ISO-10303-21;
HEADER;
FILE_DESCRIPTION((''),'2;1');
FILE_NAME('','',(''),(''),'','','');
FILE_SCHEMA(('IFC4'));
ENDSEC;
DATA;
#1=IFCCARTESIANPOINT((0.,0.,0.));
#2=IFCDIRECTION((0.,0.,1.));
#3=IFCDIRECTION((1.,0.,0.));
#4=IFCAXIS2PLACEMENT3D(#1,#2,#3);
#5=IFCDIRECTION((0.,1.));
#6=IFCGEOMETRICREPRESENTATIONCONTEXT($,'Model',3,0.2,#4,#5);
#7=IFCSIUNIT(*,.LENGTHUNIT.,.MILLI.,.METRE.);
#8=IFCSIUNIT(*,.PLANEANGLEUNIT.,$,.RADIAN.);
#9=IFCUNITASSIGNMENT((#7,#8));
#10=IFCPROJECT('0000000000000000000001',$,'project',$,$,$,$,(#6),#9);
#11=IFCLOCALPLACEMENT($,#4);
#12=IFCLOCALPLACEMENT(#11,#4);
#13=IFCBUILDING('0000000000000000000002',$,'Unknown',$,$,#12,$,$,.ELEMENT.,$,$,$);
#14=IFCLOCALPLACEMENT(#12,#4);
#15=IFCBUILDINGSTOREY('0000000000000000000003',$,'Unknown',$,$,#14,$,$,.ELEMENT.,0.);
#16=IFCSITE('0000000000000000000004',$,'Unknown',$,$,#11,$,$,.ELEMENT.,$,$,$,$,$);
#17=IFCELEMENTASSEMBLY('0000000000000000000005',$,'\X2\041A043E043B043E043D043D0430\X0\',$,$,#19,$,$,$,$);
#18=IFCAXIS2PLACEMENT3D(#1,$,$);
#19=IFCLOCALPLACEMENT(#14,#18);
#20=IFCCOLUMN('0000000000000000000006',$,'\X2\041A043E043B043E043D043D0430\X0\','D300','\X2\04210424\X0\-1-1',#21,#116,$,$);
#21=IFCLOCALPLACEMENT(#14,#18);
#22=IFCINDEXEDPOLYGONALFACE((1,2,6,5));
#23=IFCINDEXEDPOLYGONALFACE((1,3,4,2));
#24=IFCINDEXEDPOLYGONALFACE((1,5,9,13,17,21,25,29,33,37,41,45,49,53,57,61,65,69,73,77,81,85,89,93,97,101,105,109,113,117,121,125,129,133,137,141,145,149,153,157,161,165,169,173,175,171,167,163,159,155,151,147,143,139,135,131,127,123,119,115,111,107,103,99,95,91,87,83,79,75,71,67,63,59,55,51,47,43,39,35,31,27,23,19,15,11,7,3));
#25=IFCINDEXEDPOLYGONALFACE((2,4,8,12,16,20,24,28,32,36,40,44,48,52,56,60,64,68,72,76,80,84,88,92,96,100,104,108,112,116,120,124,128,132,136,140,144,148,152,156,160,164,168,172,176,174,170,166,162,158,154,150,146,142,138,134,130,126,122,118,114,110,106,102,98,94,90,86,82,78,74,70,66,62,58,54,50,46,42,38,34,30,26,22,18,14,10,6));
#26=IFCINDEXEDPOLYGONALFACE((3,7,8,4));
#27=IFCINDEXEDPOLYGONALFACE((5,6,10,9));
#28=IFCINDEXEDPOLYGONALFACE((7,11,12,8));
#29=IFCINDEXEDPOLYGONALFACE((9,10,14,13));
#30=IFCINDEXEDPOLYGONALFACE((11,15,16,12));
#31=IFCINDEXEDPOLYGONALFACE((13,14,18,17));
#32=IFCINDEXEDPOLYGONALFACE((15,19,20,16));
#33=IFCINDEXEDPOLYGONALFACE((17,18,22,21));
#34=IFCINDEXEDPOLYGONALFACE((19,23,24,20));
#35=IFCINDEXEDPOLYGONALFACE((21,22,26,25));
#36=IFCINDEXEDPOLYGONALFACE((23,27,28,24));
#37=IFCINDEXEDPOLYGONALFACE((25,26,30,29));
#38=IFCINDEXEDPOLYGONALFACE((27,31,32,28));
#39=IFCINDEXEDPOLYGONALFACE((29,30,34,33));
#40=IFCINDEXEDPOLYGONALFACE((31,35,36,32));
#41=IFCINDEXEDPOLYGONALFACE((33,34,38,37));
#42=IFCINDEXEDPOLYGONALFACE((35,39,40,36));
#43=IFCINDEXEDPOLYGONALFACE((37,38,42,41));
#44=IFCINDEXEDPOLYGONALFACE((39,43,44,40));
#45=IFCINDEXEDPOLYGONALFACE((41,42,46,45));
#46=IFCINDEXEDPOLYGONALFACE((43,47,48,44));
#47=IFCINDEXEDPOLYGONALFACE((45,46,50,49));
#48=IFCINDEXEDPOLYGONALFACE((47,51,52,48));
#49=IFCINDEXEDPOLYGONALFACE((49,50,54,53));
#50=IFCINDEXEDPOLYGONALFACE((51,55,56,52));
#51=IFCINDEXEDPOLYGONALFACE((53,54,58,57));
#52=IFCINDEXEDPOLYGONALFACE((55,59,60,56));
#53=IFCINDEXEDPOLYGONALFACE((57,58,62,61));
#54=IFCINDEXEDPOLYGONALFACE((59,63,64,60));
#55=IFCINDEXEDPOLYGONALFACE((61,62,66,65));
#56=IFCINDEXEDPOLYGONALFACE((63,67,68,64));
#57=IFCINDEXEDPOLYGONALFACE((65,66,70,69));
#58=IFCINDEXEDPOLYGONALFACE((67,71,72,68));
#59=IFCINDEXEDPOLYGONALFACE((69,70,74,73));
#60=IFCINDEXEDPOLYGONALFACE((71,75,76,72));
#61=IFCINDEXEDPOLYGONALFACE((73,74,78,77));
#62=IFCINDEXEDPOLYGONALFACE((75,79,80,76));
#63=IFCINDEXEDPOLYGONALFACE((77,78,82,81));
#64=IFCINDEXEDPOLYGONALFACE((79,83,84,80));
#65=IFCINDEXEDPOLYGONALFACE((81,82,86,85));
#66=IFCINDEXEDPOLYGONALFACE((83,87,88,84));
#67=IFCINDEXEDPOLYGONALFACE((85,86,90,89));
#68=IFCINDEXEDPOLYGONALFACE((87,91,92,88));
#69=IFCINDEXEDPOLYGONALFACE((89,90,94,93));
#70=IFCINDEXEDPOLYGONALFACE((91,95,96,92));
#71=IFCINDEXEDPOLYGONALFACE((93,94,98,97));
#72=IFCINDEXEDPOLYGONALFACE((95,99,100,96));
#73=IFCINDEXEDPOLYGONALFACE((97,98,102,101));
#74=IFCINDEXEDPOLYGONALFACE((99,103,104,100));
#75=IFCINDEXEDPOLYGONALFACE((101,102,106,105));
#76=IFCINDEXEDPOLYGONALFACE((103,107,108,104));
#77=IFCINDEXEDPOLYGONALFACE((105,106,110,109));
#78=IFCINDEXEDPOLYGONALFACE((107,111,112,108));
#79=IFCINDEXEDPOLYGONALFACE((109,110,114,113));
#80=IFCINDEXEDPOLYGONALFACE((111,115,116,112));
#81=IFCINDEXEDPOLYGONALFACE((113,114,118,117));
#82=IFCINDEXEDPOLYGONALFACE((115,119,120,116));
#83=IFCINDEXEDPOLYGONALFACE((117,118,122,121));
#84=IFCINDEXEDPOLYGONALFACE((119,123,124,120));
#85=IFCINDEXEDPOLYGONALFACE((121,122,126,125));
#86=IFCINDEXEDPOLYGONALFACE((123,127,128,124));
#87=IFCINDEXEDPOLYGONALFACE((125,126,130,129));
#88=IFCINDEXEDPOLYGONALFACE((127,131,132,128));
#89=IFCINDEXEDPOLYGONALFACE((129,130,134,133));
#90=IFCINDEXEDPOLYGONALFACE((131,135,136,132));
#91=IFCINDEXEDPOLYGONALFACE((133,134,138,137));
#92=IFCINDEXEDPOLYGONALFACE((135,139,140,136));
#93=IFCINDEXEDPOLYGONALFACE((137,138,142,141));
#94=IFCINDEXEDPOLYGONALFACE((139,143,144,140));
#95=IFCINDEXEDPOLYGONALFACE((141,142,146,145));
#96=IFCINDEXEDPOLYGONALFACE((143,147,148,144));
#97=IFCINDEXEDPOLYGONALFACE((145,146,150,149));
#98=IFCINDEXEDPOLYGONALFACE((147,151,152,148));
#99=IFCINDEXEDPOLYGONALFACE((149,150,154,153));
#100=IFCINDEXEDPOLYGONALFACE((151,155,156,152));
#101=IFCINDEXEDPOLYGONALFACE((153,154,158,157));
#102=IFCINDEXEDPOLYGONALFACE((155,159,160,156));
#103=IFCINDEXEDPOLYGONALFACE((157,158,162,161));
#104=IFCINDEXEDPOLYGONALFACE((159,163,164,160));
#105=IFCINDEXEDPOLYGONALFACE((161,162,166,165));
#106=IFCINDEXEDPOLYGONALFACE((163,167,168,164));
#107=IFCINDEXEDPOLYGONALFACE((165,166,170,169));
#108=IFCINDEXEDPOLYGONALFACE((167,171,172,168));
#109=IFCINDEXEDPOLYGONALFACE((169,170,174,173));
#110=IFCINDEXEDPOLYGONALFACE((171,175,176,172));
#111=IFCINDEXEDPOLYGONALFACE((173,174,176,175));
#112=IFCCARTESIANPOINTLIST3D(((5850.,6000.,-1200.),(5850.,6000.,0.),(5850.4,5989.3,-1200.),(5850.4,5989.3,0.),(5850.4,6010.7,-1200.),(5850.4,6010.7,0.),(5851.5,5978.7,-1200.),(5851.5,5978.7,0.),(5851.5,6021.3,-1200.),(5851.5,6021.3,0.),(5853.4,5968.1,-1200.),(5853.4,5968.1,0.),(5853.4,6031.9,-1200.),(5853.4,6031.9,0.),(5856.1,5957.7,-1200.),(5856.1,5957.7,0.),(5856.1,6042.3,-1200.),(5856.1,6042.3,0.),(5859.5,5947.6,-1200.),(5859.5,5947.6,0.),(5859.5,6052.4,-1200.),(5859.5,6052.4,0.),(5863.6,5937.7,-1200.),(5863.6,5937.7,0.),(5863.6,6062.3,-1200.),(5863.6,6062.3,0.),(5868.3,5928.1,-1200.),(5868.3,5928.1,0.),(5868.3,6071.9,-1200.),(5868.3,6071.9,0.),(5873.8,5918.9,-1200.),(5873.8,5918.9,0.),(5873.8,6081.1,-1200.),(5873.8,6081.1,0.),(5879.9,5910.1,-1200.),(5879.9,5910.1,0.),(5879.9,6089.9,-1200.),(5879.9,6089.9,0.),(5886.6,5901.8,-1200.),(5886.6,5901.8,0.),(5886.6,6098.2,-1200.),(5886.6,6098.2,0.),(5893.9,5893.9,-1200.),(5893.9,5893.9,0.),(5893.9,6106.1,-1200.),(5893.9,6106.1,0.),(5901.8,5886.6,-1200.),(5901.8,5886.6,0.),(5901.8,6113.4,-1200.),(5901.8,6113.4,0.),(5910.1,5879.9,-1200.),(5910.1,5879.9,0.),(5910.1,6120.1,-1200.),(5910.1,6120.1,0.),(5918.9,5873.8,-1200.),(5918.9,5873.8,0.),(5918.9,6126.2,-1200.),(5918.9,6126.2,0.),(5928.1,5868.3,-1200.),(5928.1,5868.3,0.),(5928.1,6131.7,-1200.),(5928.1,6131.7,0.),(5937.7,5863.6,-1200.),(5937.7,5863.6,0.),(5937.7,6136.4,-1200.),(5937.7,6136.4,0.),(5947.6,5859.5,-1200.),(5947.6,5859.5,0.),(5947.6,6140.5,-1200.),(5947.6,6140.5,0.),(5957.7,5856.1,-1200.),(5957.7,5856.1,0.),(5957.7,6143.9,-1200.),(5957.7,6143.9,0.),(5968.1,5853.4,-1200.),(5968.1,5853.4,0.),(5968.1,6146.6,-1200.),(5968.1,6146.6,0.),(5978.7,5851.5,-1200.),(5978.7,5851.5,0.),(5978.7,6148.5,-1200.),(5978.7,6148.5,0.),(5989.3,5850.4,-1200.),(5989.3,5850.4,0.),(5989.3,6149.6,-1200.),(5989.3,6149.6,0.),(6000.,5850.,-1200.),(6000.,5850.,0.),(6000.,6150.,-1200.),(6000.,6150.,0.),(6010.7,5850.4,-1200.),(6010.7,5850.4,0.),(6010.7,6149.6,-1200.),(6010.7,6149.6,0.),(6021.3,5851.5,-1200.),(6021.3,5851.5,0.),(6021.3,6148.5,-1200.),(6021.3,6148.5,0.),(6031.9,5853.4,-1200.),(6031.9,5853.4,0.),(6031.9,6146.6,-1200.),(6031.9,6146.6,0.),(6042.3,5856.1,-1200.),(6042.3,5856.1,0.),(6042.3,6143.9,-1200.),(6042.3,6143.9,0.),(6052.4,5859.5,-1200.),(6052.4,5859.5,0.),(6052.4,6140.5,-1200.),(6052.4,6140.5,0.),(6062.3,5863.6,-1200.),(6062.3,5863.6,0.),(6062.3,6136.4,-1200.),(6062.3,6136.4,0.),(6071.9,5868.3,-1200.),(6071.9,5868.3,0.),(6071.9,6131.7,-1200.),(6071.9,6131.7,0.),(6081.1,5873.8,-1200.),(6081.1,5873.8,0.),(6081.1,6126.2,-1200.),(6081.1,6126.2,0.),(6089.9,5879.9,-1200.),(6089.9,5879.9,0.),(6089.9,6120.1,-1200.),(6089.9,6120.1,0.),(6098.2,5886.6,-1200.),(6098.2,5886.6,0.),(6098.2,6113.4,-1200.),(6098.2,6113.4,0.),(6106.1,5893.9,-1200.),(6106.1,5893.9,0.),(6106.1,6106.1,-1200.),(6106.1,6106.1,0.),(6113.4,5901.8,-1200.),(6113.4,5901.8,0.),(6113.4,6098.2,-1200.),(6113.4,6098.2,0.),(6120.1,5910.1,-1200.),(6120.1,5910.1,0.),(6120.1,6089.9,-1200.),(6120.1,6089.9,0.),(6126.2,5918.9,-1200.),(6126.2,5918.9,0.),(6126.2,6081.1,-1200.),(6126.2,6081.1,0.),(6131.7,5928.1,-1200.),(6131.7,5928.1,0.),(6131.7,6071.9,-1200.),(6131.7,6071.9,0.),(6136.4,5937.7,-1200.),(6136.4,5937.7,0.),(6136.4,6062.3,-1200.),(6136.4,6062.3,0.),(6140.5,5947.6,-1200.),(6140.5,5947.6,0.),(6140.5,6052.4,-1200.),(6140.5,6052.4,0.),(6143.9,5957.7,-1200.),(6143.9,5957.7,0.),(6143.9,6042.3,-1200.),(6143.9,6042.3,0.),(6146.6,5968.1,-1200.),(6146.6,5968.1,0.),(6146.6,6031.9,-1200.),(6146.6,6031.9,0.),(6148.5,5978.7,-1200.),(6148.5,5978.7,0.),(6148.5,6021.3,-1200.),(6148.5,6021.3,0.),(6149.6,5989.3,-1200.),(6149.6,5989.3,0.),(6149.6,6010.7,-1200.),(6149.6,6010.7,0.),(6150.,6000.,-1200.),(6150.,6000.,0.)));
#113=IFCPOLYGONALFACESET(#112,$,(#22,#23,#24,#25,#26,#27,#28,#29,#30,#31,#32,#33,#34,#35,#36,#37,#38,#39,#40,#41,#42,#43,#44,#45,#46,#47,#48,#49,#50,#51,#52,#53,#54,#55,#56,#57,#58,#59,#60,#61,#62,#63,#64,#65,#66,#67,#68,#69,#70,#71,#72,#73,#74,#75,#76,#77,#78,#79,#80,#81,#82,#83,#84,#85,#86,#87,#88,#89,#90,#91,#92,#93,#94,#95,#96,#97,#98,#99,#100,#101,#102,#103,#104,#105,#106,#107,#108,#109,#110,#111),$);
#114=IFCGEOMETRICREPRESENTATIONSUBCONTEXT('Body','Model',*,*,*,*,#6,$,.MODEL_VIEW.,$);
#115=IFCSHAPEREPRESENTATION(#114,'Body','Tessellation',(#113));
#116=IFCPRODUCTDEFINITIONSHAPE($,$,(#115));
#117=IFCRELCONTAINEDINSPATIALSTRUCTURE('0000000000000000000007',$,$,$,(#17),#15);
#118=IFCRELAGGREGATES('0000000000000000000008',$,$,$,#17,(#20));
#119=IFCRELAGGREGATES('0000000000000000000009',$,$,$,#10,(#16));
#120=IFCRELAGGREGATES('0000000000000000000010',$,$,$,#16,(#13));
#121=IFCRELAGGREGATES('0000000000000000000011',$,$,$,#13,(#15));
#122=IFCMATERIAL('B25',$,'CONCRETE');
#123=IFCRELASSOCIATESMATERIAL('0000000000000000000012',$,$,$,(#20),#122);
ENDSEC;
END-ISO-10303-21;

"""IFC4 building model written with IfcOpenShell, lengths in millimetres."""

from ifc_helpers import new_model, si_unit, direction, frame, origin_with_axes, place, context, subcontext, project, spatial, line, indexed_curve, outline, extrude, material, element, aggregate, save


model = new_model("IFC4")

# Units and contexts
model_context = context("Model", 3, precision=0.2, world=origin_with_axes(), true_north=direction((0.0, 1.0)))
body_context = subcontext(model_context, "Body", "Model", "MODEL_VIEW")
ifc_project = project(units=[si_unit("LENGTHUNIT", "METRE", prefix="MILLI"), si_unit("PLANEANGLEUNIT", "RADIAN")], contexts=[model_context])

# Site, building, storey
site_placement = place(None, origin_with_axes())
site = spatial("IfcSite", under=ifc_project, at=site_placement, Name="Unknown", CompositionType="ELEMENT")
building_placement = place(site_placement, origin_with_axes())
building = spatial("IfcBuilding", under=site, at=building_placement, Name="Unknown", CompositionType="ELEMENT")
storey_placement = place(building_placement, origin_with_axes())
storey = spatial("IfcBuildingStorey", under=building, at=storey_placement, Name="Unknown", CompositionType="ELEMENT", Elevation=0.0)

# Element assembly, column
assembly_1_placement = place(storey_placement, frame((6000.0, 6000.0, -1200.0), z_axis=(-1.0, 0.0, 0.0), x_axis=(0.0, 0.0, 1.0)))
assembly_1 = element("IfcElementAssembly", 1, at=assembly_1_placement, inside=storey, Name="Колонна")
ifc_material_1 = material(Name="B25", Category="CONCRETE")
column_1_placement = place(assembly_1_placement, origin_with_axes())
column_1 = element("IfcColumn", 2, at=column_1_placement, material=ifc_material_1, Name="Колонна", Description="D300", ObjectType="СФ-1-1", context=body_context, shape_type="SolidModel", body=[
    extrude(outline(indexed_curve([(150.0, 0.0), (149.6, 10.7), (148.5, 21.3), (146.6, 31.9), (143.9, 42.3), (140.5, 52.4), (136.4, 62.3), (131.7, 71.9), (126.2, 81.1), (120.1, 89.9), (113.4, 98.2), (106.1, 106.1), (98.2, 113.4), (89.9, 120.1), (81.1, 126.2), (71.9, 131.7), (62.3, 136.4), (52.4, 140.5), (42.3, 143.9), (31.9, 146.6), (21.3, 148.5), (10.7, 149.6), (0.0, 150.0), (-10.7, 149.6), (-21.3, 148.5), (-31.9, 146.6), (-42.3, 143.9), (-52.4, 140.5), (-62.3, 136.4), (-71.9, 131.7), (-81.1, 126.2), (-89.9, 120.1), (-98.2, 113.4), (-106.1, 106.1), (-113.4, 98.2), (-120.1, 89.9), (-126.2, 81.1), (-131.7, 71.9), (-136.4, 62.3), (-140.5, 52.4), (-143.9, 42.3), (-146.6, 31.9), (-148.5, 21.3), (-149.6, 10.7), (-150.0, 0.0), (-149.6, -10.7), (-148.5, -21.3), (-146.6, -31.9), (-143.9, -42.3), (-140.5, -52.4), (-136.4, -62.3), (-131.7, -71.9), (-126.2, -81.1), (-120.1, -89.9), (-113.4, -98.2), (-106.1, -106.1), (-98.2, -113.4), (-89.9, -120.1), (-81.1, -126.2), (-71.9, -131.7), (-62.3, -136.4), (-52.4, -140.5), (-42.3, -143.9), (-31.9, -146.6), (-21.3, -148.5), (-10.7, -149.6), (0.0, -150.0), (10.7, -149.6), (21.3, -148.5), (31.9, -146.6), (42.3, -143.9), (52.4, -140.5), (62.3, -136.4), (71.9, -131.7), (81.1, -126.2), (89.9, -120.1), (98.2, -113.4), (106.1, -106.1), (113.4, -98.2), (120.1, -89.9), (126.2, -81.1), (131.7, -71.9), (136.4, -62.3), (140.5, -52.4), (143.9, -42.3), (146.6, -31.9), (148.5, -21.3), (149.6, -10.7)], segments=[line(1, 2, 3, 4, 5, 6, 7, 8, 9, 10, 11, 12, 13, 14, 15, 16, 17, 18, 19, 20, 21, 22, 23, 24, 25, 26, 27, 28, 29, 30, 31, 32, 33, 34, 35, 36, 37, 38, 39, 40, 41, 42, 43, 44, 45, 46, 47, 48, 49, 50, 51, 52, 53, 54, 55, 56, 57, 58, 59, 60, 61, 62, 63, 64, 65, 66, 67, 68, 69, 70, 71, 72, 73, 74, 75, 76, 77, 78, 79, 80, 81, 82, 83, 84, 85, 86, 87, 88, 1)])), frame((0.0, 0.0, 0.0), z_axis=(-1.0, 0.0, 0.0), x_axis=(0.0, 0.0, 1.0)), (0.0, 0.0, -1.0), 1200.0),
])
aggregate(assembly_1, [column_1])

save(model, "model.ifc")
